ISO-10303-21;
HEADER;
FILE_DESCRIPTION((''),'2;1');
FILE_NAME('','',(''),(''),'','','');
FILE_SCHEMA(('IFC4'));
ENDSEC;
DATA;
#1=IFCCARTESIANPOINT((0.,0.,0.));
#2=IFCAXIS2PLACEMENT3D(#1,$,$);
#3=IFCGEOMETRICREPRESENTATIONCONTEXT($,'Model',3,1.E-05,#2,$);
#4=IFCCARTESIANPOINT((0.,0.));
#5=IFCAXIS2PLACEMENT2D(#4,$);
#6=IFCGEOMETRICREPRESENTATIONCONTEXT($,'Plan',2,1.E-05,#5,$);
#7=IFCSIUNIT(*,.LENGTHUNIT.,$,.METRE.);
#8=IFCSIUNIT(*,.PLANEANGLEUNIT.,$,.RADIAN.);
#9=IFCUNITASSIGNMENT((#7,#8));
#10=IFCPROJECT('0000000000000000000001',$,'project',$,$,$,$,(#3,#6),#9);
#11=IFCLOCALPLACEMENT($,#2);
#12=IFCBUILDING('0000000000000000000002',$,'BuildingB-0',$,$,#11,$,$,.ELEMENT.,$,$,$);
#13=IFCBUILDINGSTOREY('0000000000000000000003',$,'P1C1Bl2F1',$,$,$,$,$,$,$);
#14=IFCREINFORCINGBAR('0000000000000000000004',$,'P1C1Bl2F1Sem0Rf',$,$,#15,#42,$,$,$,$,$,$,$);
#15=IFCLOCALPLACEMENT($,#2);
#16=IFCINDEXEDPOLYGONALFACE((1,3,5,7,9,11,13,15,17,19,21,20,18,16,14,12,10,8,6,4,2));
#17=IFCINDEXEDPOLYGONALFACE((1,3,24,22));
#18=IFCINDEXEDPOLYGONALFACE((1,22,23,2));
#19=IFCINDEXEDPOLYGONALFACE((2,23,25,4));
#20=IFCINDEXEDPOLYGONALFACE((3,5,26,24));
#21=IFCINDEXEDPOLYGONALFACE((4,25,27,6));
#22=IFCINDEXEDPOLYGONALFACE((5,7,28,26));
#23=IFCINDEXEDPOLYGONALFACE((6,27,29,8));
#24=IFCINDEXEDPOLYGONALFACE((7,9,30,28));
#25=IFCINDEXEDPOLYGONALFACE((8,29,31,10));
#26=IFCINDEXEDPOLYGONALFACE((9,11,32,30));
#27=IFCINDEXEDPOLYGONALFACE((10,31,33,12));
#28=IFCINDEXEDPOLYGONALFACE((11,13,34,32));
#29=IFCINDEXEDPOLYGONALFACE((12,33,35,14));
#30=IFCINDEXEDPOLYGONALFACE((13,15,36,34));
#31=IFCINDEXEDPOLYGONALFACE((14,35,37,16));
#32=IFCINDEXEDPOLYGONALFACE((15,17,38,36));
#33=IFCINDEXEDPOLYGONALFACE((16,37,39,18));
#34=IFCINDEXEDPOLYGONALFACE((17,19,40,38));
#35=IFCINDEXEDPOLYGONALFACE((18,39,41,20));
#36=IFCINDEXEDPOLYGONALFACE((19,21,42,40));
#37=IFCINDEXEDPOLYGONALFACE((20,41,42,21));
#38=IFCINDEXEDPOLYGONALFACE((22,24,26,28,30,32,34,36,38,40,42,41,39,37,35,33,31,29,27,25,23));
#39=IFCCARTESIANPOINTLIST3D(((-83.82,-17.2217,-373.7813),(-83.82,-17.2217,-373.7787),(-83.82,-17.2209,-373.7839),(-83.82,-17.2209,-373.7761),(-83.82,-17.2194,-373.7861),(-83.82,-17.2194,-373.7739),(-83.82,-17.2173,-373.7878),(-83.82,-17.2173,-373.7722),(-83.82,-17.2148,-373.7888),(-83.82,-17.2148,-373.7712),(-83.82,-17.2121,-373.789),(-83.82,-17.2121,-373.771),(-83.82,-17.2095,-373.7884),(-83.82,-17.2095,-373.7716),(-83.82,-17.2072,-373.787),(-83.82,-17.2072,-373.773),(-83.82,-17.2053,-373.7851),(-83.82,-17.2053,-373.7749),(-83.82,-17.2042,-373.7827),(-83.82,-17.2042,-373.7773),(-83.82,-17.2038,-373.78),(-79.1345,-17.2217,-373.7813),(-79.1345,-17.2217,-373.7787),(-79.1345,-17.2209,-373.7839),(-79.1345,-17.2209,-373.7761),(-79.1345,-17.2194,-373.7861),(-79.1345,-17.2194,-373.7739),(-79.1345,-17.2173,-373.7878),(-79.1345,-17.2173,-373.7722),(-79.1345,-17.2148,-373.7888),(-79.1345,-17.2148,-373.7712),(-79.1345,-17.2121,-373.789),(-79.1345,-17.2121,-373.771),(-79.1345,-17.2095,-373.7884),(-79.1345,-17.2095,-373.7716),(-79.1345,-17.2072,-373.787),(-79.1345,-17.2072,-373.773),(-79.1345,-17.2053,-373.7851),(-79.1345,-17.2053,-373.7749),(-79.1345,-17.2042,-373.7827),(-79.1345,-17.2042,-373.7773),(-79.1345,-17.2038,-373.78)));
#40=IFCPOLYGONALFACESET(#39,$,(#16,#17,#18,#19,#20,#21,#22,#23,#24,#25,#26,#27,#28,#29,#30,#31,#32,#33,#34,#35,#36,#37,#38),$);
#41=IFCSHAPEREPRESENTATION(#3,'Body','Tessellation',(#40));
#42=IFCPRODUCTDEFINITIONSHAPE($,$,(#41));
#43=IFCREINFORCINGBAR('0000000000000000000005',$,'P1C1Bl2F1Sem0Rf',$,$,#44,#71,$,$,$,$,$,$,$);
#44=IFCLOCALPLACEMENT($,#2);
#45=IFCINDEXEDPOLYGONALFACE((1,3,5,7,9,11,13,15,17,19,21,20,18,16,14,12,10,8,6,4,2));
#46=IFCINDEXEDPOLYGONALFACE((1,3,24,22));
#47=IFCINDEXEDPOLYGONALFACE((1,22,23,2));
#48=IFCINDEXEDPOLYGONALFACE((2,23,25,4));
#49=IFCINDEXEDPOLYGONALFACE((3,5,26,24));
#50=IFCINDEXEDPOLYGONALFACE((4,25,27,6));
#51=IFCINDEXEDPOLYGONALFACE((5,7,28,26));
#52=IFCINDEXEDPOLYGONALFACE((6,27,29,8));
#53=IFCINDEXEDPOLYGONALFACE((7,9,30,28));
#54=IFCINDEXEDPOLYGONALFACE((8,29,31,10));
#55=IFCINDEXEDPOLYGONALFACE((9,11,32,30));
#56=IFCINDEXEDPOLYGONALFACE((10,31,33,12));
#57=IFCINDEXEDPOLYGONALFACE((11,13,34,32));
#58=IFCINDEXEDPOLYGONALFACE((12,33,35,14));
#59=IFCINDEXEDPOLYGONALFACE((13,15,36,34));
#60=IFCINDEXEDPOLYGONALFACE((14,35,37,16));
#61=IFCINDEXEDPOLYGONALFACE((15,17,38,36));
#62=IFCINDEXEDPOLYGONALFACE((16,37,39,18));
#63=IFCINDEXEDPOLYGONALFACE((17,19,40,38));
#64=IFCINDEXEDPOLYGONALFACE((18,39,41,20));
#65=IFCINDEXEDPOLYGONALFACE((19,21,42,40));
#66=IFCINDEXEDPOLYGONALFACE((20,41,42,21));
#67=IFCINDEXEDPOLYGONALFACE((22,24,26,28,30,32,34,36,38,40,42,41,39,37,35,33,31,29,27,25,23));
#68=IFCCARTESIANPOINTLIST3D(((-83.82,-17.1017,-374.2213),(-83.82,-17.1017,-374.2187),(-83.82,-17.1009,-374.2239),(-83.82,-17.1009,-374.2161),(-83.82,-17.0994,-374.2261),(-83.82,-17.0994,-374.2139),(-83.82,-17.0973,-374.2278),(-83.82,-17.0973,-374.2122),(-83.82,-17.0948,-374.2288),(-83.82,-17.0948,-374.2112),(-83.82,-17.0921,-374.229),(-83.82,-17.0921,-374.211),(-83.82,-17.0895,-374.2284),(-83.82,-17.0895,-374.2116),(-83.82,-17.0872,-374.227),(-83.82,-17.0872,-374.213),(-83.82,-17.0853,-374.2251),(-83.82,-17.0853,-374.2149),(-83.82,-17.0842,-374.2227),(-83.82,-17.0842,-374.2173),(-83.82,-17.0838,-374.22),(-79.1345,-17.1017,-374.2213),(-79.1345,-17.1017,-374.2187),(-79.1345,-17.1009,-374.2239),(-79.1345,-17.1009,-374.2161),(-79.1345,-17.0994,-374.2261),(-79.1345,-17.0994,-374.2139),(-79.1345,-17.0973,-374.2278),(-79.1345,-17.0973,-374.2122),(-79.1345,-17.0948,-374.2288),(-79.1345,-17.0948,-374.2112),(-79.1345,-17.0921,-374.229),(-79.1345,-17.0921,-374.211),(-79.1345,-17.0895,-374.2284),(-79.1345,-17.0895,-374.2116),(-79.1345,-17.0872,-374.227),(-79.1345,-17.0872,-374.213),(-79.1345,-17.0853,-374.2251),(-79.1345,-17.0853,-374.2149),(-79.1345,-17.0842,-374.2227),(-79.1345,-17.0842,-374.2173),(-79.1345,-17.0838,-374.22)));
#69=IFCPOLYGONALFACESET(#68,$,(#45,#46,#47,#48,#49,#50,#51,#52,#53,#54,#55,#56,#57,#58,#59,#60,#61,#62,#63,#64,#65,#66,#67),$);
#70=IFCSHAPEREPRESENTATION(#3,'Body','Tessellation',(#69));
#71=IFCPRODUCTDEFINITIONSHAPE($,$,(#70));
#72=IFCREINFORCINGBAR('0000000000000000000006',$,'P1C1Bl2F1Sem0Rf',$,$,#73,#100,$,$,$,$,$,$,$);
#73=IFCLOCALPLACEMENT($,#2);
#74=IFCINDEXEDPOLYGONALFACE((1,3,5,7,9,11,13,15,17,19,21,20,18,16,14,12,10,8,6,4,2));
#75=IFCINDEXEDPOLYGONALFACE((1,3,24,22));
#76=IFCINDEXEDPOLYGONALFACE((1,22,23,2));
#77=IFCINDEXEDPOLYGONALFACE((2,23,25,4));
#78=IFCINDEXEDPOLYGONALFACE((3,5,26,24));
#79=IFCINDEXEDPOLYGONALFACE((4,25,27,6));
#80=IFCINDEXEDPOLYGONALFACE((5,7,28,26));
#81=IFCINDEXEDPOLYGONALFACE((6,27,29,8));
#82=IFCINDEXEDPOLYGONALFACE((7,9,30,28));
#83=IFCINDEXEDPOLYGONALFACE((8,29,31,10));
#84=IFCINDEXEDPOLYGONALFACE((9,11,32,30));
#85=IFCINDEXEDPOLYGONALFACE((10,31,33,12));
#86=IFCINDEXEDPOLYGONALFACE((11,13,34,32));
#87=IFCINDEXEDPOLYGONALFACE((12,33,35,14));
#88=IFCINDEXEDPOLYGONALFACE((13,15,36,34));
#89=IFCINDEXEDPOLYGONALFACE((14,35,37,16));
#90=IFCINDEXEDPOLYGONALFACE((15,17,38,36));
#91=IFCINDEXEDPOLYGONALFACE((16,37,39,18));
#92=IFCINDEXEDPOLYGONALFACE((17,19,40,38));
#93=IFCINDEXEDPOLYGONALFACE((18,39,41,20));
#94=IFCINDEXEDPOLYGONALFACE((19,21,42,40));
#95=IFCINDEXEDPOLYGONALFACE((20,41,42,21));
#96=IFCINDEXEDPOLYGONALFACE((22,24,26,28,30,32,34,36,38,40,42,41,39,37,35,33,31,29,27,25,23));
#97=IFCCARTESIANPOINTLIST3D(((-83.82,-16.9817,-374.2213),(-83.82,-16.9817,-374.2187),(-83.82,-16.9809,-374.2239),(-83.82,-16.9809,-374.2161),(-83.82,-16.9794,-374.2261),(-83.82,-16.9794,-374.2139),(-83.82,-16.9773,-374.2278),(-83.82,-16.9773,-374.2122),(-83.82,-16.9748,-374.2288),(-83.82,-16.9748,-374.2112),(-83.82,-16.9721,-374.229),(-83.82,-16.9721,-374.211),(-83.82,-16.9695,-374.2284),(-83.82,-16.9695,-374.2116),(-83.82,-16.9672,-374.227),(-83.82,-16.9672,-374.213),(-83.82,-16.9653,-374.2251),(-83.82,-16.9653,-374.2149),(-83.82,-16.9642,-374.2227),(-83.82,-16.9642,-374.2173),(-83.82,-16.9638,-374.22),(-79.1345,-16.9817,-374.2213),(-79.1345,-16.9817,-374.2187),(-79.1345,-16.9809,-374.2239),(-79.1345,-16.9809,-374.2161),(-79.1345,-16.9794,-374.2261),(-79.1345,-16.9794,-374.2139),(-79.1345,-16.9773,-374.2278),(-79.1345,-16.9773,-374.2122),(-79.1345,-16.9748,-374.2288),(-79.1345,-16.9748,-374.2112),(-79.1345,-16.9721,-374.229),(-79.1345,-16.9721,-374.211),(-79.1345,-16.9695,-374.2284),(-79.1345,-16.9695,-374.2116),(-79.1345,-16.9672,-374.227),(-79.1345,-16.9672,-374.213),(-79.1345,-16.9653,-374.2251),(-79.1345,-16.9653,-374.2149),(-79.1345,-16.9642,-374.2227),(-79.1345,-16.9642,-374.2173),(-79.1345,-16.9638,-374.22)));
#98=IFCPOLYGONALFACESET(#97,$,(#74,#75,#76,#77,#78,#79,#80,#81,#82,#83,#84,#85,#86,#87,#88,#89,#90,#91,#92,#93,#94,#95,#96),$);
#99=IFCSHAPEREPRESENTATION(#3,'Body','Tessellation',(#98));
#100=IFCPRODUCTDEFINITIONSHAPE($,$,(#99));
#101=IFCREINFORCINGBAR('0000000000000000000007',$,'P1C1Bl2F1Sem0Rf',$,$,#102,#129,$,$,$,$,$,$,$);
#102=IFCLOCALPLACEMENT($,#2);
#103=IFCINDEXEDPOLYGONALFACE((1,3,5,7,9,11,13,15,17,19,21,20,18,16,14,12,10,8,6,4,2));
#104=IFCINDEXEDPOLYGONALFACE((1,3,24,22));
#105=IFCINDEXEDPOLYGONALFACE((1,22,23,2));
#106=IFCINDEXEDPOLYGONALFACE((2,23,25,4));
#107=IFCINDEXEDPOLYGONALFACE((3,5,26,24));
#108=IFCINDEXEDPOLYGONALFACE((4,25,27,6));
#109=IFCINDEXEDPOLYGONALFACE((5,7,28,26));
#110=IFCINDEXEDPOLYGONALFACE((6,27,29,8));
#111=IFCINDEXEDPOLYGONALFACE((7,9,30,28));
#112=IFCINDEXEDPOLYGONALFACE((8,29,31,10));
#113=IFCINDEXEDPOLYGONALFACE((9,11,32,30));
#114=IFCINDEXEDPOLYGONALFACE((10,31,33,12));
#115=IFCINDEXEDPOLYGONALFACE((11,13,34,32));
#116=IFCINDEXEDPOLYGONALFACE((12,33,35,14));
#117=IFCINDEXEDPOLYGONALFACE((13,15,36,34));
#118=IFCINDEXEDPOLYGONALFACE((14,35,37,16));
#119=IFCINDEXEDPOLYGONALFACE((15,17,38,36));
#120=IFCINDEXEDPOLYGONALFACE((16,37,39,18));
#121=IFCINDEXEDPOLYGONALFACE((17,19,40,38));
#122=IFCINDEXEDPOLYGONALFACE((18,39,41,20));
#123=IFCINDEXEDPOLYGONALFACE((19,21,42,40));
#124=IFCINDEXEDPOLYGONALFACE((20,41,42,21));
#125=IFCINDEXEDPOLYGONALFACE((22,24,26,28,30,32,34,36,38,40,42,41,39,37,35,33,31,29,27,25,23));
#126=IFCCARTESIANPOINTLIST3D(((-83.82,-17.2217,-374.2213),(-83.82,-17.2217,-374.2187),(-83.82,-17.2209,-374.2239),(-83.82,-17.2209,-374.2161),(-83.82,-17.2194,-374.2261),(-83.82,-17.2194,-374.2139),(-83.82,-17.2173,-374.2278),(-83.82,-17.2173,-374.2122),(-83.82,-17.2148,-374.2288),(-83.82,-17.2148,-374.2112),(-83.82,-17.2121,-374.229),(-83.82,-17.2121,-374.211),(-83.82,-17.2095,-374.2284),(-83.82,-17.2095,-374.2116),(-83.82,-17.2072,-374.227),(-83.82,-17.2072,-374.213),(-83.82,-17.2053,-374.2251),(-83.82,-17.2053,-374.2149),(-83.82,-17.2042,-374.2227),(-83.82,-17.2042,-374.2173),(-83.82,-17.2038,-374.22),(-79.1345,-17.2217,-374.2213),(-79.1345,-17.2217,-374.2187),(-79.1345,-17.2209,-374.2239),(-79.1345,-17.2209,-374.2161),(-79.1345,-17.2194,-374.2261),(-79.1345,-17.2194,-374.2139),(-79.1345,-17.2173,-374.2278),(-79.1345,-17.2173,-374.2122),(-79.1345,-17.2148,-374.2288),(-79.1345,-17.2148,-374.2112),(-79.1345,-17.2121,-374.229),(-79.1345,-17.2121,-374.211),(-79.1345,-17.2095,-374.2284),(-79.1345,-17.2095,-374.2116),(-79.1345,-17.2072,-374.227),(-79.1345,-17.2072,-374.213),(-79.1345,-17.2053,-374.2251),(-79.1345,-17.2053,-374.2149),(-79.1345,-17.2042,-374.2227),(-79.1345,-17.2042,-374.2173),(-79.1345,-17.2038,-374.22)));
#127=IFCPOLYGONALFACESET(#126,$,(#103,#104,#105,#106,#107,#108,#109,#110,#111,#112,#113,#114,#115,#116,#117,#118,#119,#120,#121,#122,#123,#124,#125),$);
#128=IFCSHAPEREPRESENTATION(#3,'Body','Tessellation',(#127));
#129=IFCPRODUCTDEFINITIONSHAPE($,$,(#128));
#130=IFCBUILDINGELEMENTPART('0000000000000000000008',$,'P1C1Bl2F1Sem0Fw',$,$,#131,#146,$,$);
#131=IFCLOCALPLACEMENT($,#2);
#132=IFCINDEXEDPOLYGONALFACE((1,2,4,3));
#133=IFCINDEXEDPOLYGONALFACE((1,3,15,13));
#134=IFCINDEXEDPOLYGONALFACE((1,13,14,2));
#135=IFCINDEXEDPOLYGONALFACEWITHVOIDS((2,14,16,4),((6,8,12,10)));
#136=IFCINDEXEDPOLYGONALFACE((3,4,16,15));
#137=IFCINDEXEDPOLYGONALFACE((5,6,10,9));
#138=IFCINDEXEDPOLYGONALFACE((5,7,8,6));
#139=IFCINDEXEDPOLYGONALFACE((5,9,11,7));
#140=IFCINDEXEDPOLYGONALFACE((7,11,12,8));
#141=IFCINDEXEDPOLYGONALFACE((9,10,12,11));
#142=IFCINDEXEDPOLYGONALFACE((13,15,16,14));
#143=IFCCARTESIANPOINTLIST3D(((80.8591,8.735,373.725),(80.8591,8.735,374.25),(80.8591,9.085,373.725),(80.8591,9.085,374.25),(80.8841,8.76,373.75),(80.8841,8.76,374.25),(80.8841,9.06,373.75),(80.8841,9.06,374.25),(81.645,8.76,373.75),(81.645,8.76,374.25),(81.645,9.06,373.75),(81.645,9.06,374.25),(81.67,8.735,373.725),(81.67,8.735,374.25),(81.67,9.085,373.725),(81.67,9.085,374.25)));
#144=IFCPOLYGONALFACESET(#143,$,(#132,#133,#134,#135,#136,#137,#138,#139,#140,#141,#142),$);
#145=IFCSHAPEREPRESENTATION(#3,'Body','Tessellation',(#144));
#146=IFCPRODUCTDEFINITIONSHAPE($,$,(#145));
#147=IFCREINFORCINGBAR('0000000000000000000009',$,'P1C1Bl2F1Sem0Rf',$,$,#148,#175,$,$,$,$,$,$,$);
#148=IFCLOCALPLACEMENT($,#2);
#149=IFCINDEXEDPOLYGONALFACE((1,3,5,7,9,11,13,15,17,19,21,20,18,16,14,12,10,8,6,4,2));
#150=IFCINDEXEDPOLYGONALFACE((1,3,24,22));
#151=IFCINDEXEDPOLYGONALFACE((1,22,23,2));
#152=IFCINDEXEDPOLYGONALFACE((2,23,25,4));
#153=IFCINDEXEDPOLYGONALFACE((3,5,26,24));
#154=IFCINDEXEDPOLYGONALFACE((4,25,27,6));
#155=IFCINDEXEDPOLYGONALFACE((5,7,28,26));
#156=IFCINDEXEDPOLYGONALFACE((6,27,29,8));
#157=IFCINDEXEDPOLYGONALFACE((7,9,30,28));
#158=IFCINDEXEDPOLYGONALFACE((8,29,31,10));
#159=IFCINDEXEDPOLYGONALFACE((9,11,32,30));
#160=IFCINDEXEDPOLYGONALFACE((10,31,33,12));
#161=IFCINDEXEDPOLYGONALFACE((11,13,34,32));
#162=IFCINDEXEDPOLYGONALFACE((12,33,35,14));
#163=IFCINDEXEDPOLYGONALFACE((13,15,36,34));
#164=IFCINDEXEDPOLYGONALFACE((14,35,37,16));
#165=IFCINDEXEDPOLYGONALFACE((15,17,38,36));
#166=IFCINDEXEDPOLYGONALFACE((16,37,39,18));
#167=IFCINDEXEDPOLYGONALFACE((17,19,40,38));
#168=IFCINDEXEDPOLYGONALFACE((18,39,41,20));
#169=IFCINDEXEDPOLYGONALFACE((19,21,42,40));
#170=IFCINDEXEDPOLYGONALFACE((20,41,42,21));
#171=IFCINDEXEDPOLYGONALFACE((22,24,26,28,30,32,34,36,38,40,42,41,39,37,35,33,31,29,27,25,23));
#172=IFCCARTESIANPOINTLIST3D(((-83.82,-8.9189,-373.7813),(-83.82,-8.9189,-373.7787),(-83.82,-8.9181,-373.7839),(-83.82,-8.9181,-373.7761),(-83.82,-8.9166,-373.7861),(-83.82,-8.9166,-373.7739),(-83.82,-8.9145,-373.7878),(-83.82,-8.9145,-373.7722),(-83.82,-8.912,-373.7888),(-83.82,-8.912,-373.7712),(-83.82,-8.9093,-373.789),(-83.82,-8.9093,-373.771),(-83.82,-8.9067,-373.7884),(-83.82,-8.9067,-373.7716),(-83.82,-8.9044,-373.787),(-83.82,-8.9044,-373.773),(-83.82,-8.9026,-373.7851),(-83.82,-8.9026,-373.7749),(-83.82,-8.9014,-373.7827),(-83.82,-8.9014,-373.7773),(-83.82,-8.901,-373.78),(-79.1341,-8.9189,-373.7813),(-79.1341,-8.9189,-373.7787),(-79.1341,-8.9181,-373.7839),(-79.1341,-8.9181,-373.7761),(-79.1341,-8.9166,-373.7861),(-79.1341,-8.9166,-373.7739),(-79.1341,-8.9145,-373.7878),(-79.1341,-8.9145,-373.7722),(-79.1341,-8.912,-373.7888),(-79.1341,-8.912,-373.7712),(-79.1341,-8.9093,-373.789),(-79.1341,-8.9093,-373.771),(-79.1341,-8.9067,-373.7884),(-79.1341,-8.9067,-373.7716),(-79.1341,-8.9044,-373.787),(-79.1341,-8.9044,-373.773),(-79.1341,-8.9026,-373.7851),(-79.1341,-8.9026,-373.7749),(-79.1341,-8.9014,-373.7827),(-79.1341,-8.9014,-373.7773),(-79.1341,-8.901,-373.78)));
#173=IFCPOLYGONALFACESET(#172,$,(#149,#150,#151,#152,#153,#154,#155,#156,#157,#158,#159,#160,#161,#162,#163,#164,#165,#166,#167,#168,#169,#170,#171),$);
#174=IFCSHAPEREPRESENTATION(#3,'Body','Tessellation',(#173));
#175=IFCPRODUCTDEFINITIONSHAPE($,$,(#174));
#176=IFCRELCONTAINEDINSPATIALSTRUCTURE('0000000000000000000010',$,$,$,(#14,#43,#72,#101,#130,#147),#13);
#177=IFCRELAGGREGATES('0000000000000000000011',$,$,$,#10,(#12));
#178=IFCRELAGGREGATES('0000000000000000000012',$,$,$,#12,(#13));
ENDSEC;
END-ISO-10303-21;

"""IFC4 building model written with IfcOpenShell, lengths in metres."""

from ifc_helpers import new_model, entity, si_unit, origin, origin_2d, place, context, project, spatial, polyline, outline, extrude, element, save


model = new_model("IFC4")

# Units and contexts
model_context = context("Model", 3, precision=1e-05, world=origin())
plan_context = context("Plan", 2, precision=1e-05, world=origin_2d())
ifc_project = project(units=[si_unit("LENGTHUNIT", "METRE"), si_unit("PLANEANGLEUNIT", "RADIAN")], contexts=[model_context, plan_context])

# Building, storey
building_placement = place(None, origin())
building = spatial("IfcBuilding", under=ifc_project, at=building_placement, Name="BuildingB-0", CompositionType="ELEMENT")
storey = spatial("IfcBuildingStorey", under=building, Name="P1C1Bl2F1")

# Reinforcing bars
element("IfcReinforcingBar", 1, inside=storey, Name="P1C1Bl2F1Sem0Rf", context=model_context, shape_type="SweptSolid", body=[
    entity("IfcSurfaceCurveSweptAreaSolid", entity("IfcCircleProfileDef", "AREA", None, None, 0.009), None, entity("IfcPolyline", [entity("IfcCartesianPoint", [79.1345, 17.2128, 373.78]), entity("IfcCartesianPoint", [83.82, 17.2128, 373.78])]), None, None, entity("IfcPlane", entity("IfcAxis2Placement3D", entity("IfcCartesianPoint", [79.1345, 17.2128, 373.78]), entity("IfcDirection", [0.0, 0.0, 1.0]), entity("IfcDirection", [1.0, 0.0, 0.0])))),
])
element("IfcReinforcingBar", 2, inside=storey, Name="P1C1Bl2F1Sem0Rf", context=model_context, shape_type="SweptSolid", body=[
    entity("IfcSurfaceCurveSweptAreaSolid", entity("IfcCircleProfileDef", "AREA", None, None, 0.009), None, entity("IfcPolyline", [entity("IfcCartesianPoint", [79.1345, 17.0928, 374.22]), entity("IfcCartesianPoint", [83.82, 17.0928, 374.22])]), None, None, entity("IfcPlane", entity("IfcAxis2Placement3D", entity("IfcCartesianPoint", [79.1345, 17.0928, 374.22]), entity("IfcDirection", [0.0, 0.0, 1.0]), entity("IfcDirection", [1.0, 0.0, 0.0])))),
])
element("IfcReinforcingBar", 3, inside=storey, Name="P1C1Bl2F1Sem0Rf", context=model_context, shape_type="SweptSolid", body=[
    entity("IfcSurfaceCurveSweptAreaSolid", entity("IfcCircleProfileDef", "AREA", None, None, 0.009), None, entity("IfcPolyline", [entity("IfcCartesianPoint", [79.1345, 16.9728, 374.22]), entity("IfcCartesianPoint", [83.82, 16.9728, 374.22])]), None, None, entity("IfcPlane", entity("IfcAxis2Placement3D", entity("IfcCartesianPoint", [79.1345, 16.9728, 374.22]), entity("IfcDirection", [0.0, 0.0, 1.0]), entity("IfcDirection", [1.0, 0.0, 0.0])))),
])
element("IfcReinforcingBar", 4, inside=storey, Name="P1C1Bl2F1Sem0Rf", context=model_context, shape_type="SweptSolid", body=[
    entity("IfcSurfaceCurveSweptAreaSolid", entity("IfcCircleProfileDef", "AREA", None, None, 0.009), None, entity("IfcPolyline", [entity("IfcCartesianPoint", [79.1345, 17.2128, 374.22]), entity("IfcCartesianPoint", [83.82, 17.2128, 374.22])]), None, None, entity("IfcPlane", entity("IfcAxis2Placement3D", entity("IfcCartesianPoint", [79.1345, 17.2128, 374.22]), entity("IfcDirection", [0.0, 0.0, 1.0]), entity("IfcDirection", [1.0, 0.0, 0.0])))),
])

# Building element part, opening
building_element_part_1 = element("IfcBuildingElementPart", 5, inside=storey, Name="P1C1Bl2F1Sem0Fw", context=model_context, shape_type="SweptSolid", body=[
    extrude(outline(polyline([(81.67, 8.735, 373.725), (80.8591, 8.735, 373.725), (80.8591, 9.085, 373.725), (81.67, 9.085, 373.725), (81.67, 8.735, 373.725)])), None, (0.0, 0.0, 1.0), 0.525),
])
element("IfcOpeningElement", 6, inside=storey, cuts=building_element_part_1, context=model_context, shape_type="SweptSolid", body=[
    extrude(outline(polyline([(81.645, 8.76, 373.75), (80.8841, 8.76, 373.75), (80.8841, 9.06, 373.75), (81.645, 9.06, 373.75), (81.645, 8.76, 373.75)])), None, (0.0, 0.0, 1.0), 0.5),
])

# Reinforcing bar
element("IfcReinforcingBar", 7, inside=storey, Name="P1C1Bl2F1Sem0Rf", context=model_context, shape_type="SweptSolid", body=[
    entity("IfcSurfaceCurveSweptAreaSolid", entity("IfcCircleProfileDef", "AREA", None, None, 0.009), None, entity("IfcPolyline", [entity("IfcCartesianPoint", [79.1341, 8.91, 373.78]), entity("IfcCartesianPoint", [83.82, 8.91, 373.78])]), None, None, entity("IfcPlane", entity("IfcAxis2Placement3D", entity("IfcCartesianPoint", [79.1341, 8.91, 373.78]), entity("IfcDirection", [0.0, 0.0, 1.0]), entity("IfcDirection", [1.0, 0.0, 0.0])))),
])

save(model, "model.ifc")
